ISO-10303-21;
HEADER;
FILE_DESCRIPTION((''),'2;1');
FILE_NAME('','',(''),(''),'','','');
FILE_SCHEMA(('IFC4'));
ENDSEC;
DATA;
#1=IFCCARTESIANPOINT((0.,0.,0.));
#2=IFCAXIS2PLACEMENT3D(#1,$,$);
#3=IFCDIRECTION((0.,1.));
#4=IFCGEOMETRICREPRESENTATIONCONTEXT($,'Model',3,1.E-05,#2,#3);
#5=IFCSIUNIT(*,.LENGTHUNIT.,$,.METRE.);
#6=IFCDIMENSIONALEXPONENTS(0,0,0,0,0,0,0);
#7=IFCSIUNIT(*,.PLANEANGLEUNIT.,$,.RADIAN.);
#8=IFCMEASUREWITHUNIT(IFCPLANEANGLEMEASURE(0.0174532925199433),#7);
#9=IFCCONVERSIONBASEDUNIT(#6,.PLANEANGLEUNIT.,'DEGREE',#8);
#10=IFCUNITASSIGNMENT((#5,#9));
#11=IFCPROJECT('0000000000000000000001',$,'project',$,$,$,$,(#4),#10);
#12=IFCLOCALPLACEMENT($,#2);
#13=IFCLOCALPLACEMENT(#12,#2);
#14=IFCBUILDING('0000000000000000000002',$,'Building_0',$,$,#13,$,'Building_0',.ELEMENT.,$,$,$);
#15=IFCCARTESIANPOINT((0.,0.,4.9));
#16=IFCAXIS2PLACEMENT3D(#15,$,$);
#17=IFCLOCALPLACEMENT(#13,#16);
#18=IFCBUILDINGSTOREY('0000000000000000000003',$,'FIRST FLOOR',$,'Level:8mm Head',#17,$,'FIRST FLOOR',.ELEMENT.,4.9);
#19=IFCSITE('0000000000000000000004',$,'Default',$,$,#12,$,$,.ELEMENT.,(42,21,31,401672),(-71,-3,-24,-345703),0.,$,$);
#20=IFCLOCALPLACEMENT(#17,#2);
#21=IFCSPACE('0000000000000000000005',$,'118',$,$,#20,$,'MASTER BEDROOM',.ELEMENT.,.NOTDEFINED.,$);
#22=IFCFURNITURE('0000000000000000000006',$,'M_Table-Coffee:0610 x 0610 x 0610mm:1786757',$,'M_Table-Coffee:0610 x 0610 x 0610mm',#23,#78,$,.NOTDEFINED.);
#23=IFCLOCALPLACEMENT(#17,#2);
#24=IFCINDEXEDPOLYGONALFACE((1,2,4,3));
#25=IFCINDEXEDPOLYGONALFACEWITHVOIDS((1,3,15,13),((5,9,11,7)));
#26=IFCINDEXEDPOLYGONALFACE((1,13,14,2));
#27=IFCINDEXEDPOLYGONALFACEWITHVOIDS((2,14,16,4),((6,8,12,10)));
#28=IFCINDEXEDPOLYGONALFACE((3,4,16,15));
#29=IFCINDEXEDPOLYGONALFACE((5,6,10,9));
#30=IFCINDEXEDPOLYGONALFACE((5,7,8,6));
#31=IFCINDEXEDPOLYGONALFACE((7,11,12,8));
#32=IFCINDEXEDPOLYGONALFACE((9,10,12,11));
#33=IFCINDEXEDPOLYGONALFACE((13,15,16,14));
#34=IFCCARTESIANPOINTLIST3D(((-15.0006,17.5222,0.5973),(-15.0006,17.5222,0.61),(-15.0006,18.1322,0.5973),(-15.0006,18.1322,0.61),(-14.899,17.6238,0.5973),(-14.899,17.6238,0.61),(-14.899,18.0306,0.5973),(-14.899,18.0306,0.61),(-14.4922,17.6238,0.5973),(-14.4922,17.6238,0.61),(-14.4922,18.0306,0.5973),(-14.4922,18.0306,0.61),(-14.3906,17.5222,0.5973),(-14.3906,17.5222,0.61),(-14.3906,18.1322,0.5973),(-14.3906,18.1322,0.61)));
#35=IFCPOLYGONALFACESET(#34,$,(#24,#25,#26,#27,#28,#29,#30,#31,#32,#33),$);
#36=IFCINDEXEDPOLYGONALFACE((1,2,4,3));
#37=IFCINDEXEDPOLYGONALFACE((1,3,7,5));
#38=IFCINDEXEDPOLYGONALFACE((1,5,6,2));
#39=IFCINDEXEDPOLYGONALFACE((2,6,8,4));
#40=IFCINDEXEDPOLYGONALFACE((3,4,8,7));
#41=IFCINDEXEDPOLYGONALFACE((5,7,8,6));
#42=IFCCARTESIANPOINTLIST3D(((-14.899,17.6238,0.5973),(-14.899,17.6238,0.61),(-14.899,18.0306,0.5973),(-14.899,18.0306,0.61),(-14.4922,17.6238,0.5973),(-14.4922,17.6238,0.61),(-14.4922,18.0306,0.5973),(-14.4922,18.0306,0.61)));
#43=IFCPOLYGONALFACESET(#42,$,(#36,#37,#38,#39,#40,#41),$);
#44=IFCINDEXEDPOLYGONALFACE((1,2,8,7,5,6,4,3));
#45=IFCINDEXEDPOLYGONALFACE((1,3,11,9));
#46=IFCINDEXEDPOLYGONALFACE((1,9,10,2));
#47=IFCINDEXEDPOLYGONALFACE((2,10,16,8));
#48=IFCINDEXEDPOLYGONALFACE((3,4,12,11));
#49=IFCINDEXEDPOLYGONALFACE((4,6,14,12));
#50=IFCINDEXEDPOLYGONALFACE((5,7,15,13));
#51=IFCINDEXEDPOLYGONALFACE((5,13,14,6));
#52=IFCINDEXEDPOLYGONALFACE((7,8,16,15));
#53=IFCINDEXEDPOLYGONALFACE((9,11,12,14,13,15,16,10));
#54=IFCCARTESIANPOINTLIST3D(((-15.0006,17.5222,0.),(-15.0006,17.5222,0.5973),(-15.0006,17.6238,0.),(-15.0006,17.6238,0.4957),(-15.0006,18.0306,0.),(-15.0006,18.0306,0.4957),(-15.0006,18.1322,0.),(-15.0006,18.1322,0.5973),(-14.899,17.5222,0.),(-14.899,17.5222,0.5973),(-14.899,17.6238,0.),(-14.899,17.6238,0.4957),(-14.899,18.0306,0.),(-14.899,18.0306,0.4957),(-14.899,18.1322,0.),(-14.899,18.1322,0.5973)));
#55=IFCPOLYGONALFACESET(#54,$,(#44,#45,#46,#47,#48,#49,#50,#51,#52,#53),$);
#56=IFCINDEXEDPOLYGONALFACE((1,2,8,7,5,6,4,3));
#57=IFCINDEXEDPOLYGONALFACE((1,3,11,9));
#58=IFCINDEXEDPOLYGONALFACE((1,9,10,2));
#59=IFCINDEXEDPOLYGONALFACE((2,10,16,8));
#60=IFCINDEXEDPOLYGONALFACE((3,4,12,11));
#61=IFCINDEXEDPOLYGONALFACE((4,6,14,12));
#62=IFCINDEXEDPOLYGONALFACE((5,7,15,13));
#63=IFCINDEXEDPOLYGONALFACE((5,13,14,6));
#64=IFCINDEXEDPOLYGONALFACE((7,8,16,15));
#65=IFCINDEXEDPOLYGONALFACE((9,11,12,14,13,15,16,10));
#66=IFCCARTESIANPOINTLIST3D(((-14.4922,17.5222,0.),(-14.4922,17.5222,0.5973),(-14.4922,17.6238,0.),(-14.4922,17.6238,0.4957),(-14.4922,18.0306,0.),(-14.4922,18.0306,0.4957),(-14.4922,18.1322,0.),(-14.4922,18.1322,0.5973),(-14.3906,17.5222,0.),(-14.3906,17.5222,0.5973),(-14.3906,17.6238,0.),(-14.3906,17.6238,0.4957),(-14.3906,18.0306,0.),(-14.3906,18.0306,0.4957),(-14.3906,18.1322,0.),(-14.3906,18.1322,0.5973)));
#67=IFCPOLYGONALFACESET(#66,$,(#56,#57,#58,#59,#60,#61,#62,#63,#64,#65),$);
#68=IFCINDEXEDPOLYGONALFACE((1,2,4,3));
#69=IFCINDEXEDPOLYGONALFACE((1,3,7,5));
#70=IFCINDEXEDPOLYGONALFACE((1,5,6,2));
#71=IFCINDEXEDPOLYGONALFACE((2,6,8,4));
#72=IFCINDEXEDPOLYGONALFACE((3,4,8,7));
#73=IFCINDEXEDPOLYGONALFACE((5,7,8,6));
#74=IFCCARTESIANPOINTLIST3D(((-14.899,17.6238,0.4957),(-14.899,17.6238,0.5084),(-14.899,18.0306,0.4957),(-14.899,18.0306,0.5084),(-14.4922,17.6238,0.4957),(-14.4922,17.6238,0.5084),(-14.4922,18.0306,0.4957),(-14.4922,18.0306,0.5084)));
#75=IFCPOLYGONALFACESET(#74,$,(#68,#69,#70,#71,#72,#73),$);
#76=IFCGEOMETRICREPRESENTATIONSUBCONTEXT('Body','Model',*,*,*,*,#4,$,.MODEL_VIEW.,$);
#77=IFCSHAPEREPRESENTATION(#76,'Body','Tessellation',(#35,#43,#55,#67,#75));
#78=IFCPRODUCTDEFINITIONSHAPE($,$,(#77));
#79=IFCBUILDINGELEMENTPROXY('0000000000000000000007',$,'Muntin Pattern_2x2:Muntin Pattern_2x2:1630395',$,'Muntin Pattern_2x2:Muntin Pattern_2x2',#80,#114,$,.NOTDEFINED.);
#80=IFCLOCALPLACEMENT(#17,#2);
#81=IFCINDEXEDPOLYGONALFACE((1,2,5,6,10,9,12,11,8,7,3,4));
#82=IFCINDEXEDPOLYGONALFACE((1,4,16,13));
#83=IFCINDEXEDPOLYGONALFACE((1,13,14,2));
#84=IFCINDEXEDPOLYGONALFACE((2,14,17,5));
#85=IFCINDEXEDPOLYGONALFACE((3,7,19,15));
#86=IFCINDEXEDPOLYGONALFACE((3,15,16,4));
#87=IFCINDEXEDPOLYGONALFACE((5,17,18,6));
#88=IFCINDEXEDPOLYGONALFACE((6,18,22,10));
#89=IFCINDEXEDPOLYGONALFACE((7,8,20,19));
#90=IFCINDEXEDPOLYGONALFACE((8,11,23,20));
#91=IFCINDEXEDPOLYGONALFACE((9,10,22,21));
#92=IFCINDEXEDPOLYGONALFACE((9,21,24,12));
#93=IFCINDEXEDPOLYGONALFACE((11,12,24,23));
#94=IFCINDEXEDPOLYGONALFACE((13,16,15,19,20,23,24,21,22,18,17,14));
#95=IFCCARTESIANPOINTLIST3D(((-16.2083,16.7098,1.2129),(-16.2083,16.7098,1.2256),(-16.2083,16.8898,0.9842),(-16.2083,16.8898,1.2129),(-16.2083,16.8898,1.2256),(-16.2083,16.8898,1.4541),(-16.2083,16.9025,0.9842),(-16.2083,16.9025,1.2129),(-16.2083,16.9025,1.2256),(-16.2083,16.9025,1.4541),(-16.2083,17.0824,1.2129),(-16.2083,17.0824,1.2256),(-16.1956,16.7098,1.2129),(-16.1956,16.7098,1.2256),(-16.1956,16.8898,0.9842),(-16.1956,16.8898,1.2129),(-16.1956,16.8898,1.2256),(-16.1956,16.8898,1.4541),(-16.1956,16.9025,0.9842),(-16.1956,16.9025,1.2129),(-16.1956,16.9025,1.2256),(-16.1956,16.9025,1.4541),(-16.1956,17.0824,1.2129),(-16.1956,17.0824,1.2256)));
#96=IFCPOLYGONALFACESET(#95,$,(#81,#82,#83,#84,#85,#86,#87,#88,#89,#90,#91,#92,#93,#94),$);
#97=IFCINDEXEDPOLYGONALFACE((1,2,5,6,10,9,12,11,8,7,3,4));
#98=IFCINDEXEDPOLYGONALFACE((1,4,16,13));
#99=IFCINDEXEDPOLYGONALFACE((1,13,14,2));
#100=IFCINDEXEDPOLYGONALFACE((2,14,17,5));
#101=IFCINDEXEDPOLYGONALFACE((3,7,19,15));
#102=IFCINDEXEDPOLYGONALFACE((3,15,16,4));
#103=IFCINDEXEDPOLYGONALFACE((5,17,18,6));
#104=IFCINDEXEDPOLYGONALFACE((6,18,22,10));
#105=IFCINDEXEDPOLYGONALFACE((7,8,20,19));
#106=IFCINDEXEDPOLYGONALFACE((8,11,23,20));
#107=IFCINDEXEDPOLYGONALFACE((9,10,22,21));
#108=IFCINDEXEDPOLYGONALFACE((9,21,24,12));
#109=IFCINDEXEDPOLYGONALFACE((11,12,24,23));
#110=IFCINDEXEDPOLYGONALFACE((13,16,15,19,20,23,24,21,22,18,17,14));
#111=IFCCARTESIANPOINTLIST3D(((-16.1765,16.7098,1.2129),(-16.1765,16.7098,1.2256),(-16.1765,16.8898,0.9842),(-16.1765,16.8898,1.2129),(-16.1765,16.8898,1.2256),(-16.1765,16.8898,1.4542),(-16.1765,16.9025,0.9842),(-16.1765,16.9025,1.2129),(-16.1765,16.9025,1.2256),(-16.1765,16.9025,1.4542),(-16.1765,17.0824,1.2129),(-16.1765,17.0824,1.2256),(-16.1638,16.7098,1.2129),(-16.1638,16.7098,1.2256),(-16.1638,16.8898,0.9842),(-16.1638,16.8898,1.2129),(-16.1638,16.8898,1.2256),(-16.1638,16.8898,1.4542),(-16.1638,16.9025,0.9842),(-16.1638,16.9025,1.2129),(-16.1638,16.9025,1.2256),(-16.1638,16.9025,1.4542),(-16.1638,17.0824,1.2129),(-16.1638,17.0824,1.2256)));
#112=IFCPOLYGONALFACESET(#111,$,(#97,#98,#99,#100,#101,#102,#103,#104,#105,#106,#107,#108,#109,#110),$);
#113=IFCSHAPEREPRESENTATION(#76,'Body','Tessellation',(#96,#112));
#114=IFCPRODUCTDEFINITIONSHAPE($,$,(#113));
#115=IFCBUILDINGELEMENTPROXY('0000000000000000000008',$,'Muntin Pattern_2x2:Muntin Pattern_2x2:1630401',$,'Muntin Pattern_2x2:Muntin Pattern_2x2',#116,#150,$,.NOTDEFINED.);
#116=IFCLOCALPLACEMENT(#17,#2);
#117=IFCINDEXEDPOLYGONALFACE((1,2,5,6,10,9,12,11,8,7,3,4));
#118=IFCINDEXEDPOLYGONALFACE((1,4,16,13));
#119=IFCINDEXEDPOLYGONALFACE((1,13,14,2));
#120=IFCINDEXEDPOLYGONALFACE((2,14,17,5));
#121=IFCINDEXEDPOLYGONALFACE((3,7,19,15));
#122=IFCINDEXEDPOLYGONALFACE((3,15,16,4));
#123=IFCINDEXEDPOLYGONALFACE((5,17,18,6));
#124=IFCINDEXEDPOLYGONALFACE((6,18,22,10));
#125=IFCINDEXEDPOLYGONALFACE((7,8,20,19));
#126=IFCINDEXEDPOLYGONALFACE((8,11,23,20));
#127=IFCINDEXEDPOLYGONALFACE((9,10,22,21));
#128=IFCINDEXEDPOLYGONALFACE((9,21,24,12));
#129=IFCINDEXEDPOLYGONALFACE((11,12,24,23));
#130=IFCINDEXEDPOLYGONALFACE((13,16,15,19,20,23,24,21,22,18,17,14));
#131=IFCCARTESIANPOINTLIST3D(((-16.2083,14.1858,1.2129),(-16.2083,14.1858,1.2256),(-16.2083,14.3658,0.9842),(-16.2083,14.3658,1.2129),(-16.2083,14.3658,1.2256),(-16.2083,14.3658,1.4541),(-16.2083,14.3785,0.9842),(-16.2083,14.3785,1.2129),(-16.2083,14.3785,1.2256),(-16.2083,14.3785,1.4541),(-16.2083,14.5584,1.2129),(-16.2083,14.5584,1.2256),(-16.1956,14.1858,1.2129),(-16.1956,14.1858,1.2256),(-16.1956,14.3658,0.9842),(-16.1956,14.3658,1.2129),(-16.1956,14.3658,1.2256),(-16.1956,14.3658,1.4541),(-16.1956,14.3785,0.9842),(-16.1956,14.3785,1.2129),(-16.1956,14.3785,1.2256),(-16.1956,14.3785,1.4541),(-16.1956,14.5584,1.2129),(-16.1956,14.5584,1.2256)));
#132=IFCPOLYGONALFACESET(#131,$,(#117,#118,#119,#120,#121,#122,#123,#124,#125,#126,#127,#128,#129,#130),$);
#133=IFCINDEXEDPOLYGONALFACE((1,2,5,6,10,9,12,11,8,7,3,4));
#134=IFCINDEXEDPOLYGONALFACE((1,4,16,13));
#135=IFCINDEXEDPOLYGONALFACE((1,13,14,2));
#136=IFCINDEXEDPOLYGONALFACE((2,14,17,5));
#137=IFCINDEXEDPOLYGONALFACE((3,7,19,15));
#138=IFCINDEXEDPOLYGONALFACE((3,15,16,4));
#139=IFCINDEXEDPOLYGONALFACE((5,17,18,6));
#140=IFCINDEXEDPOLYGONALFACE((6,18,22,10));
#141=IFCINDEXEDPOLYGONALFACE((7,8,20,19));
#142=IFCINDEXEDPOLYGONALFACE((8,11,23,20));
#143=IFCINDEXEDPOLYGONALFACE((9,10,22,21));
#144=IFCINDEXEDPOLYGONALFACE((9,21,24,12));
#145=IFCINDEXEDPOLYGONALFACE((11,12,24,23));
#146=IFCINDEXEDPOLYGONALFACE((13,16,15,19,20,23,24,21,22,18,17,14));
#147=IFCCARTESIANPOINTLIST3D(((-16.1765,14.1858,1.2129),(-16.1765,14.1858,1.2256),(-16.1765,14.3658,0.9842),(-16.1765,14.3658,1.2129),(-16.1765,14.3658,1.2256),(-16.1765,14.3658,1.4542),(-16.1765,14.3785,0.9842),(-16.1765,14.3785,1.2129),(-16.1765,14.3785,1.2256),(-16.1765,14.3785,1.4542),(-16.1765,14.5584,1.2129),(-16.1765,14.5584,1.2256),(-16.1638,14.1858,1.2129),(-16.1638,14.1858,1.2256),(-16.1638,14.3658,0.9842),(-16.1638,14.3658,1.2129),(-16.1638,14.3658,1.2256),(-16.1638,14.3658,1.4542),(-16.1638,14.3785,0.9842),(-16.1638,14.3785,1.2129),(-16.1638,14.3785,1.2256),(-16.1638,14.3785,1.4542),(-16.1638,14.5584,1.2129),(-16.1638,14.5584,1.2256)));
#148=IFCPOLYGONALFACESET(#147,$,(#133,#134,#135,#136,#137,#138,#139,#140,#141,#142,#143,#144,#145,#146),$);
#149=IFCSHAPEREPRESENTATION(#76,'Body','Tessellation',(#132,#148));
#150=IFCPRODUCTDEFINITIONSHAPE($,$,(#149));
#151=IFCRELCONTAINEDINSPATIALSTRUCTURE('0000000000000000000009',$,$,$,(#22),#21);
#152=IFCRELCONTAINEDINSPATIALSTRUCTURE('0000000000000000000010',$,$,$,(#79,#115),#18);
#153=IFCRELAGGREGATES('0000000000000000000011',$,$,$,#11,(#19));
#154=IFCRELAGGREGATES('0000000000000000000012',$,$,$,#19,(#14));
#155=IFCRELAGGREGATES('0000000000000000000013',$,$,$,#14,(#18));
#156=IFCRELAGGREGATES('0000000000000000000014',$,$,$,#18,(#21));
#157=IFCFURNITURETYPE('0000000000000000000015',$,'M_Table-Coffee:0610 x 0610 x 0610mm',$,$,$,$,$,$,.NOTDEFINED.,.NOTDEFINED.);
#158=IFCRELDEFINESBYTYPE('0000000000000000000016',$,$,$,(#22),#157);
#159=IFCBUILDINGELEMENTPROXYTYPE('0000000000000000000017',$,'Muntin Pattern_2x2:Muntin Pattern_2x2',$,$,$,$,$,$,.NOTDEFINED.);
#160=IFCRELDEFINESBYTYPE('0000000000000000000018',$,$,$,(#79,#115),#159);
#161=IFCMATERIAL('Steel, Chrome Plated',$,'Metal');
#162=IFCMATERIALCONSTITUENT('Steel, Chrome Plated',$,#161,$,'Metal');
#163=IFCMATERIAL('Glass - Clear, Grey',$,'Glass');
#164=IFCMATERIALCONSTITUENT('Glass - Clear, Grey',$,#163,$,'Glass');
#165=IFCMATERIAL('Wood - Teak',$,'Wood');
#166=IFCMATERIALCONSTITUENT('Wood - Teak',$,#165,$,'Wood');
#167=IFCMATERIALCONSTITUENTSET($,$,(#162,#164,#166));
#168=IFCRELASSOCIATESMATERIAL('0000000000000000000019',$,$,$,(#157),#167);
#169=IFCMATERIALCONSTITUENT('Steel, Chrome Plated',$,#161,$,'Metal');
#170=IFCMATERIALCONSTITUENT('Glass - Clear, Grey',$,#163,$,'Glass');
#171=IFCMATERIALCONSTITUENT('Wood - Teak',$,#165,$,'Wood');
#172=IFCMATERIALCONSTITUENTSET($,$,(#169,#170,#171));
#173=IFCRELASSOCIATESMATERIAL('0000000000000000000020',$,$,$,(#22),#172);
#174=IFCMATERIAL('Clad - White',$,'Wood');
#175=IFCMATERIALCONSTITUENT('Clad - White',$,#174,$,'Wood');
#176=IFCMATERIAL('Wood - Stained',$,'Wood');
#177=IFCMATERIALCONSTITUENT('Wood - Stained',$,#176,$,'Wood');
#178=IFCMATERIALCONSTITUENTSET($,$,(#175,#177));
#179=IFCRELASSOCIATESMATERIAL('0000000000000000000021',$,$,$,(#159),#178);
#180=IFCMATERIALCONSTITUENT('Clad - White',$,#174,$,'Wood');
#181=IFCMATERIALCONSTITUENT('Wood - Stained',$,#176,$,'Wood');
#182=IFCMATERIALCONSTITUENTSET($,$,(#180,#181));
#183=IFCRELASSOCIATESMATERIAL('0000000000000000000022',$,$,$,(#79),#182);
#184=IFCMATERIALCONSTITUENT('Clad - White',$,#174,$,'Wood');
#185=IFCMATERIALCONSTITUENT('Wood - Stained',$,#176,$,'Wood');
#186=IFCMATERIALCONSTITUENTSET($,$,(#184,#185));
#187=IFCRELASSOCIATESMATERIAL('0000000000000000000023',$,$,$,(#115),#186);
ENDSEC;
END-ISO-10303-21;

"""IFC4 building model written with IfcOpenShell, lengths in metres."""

from ifc_helpers import new_model, entity, si_unit, converted_unit, direction, frame, origin, place, context, subcontext, project, spatial, indexed_curve, outline, extrude, source, transform, mapped, material, constituent, constituent_set, type_object, type_shapes, element, save


model = new_model("IFC4")

# Units and contexts
model_context = context("Model", 3, precision=1e-05, world=origin(), true_north=direction((0.0, 1.0)))
body_context = subcontext(model_context, "Body", "Model", "MODEL_VIEW")
ifc_project = project(units=[si_unit("LENGTHUNIT", "METRE"), converted_unit("PLANEANGLEUNIT", "DEGREE", entity("IfcPlaneAngleMeasure", 0.0174532925199433), si_unit("PLANEANGLEUNIT", "RADIAN"), dimensions=[0, 0, 0, 0, 0, 0, 0])], contexts=[model_context])

# Site, building, storey
site_placement = place(None, origin())
site = spatial("IfcSite", under=ifc_project, at=site_placement, Name="Default", CompositionType="ELEMENT", RefLatitude=(42, 21, 31, 401672), RefLongitude=(-71, -3, -24, -345703), RefElevation=0.0)
building_placement = place(site_placement, origin())
building = spatial("IfcBuilding", under=site, at=building_placement, Name="Building_0", LongName="Building_0", CompositionType="ELEMENT")
storey_placement = place(building_placement, frame((0.0, 0.0, 4.9)))
storey = spatial("IfcBuildingStorey", under=building, at=storey_placement, Name="FIRST FLOOR", ObjectType="Level:8mm Head", LongName="FIRST FLOOR", CompositionType="ELEMENT", Elevation=4.9)

# Shared definitions
ifc_material_1 = material(Name="Clad - White", Category="Wood")

# Shared definitions
space_placement = place(storey_placement, origin())
space = spatial("IfcSpace", under=storey, at=space_placement, Name="118", LongName="MASTER BEDROOM", CompositionType="ELEMENT", PredefinedType="NOTDEFINED")

# Furniture
ifc_material_2 = material(Name="Steel, Chrome Plated", Category="Metal")
ifc_constituent_1 = constituent(ifc_material_2, Name="Steel, Chrome Plated", Category="Metal")
ifc_material_3 = material(Name="Glass - Clear, Grey", Category="Glass")
ifc_constituent_2 = constituent(ifc_material_3, Name="Glass - Clear, Grey", Category="Glass")
ifc_material_4 = material(Name="Wood - Teak", Category="Wood")
ifc_constituent_3 = constituent(ifc_material_4, Name="Wood - Teak", Category="Wood")
ifc_constituent_set_1 = constituent_set(constituents=[ifc_constituent_1, ifc_constituent_2, ifc_constituent_3])
ifc_constituent_4 = constituent(ifc_material_2, Name="Steel, Chrome Plated", Category="Metal")
ifc_constituent_5 = constituent(ifc_material_3, Name="Glass - Clear, Grey", Category="Glass")
ifc_constituent_6 = constituent(ifc_material_4, Name="Wood - Teak", Category="Wood")
ifc_constituent_set_2 = constituent_set(constituents=[ifc_constituent_4, ifc_constituent_5, ifc_constituent_6])
furniture_type = type_object("IfcFurnitureType", Name="M_Table-Coffee:0610 x 0610 x 0610mm", AssemblyPlace="NOTDEFINED", PredefinedType="NOTDEFINED", material=ifc_constituent_set_2)
shared_shape_1 = source(origin(), body_context, "Body", "SweptSolid", [
    extrude(outline(indexed_curve([(-0.305, -0.305), (0.305, -0.305), (0.305, 0.305), (-0.305, 0.305), (-0.305, -0.305)], self_intersect=False), holes=[indexed_curve([(-0.2034, -0.2034), (-0.2034, 0.2034), (0.2034, 0.2034), (0.2034, -0.2034), (-0.2034, -0.2034)], self_intersect=False)]), frame((0.0183, 0.0952, 0.5973), z_axis=(0.0, 0.0, 1.0), x_axis=(-1.0, 0.0, 0.0)), (0.0, 0.0, 1.0), 0.0127),
    extrude(outline(indexed_curve([(-0.2034, -0.2034), (0.2034, -0.2034), (0.2034, 0.2034), (-0.2034, 0.2034), (-0.2034, -0.2034)], self_intersect=False)), frame((0.0183, 0.0952, 0.5973), z_axis=(0.0, 0.0, 1.0), x_axis=(-1.0, 0.0, 0.0)), (0.0, 0.0, 1.0), 0.0127),
    extrude(outline(indexed_curve([(-0.305, -0.3241), (0.305, -0.3241), (0.305, 0.2733), (0.2034, 0.2733), (0.2034, -0.2224), (-0.2034, -0.2224), (-0.2034, 0.2733), (-0.305, 0.2733), (-0.305, -0.3241)], self_intersect=False)), frame((-0.2867, 0.0952, 0.2733), z_axis=(1.0, 0.0, 0.0), x_axis=(0.0, -1.0, 0.0)), (0.0, 0.0, 1.0), 0.1016),
    extrude(outline(indexed_curve([(-0.2732, -0.305), (0.324, -0.305), (0.324, 0.305), (-0.2732, 0.305), (-0.2732, 0.2034), (0.2225, 0.2034), (0.2225, -0.2034), (-0.2732, -0.2034), (-0.2732, -0.305)], self_intersect=False)), frame((0.2217, 0.0952, 0.2732), z_axis=(1.0, 0.0, 0.0), x_axis=(0.0, 0.0, 1.0)), (0.0, 0.0, 1.0), 0.1016),
    extrude(outline(indexed_curve([(-0.2034, -0.2034), (0.2034, -0.2034), (0.2034, 0.2034), (-0.2034, 0.2034), (-0.2034, -0.2034)], self_intersect=False)), frame((0.0183, 0.0952, 0.4957), z_axis=(0.0, 0.0, 1.0), x_axis=(-1.0, 0.0, 0.0)), (0.0, 0.0, 1.0), 0.0127),
])
type_shapes(furniture_type, [shared_shape_1])
furniture_placement = place(space_placement, frame((-14.7139, 17.732, 0.0)))
element("IfcFurniture", 1, at=furniture_placement, inside=space, type_object=furniture_type, material=ifc_constituent_set_1, Name="M_Table-Coffee:0610 x 0610 x 0610mm:1786757", ObjectType="M_Table-Coffee:0610 x 0610 x 0610mm", PredefinedType="NOTDEFINED", context=body_context, shape_type="MappedRepresentation", body=[
    mapped(shared_shape_1, transform((0.0, 0.0, 0.0), scale=1.0)),
])

# Building element proxies
ifc_constituent_7 = constituent(ifc_material_1, Name="Clad - White", Category="Wood")
ifc_material_5 = material(Name="Wood - Stained", Category="Wood")
ifc_constituent_8 = constituent(ifc_material_5, Name="Wood - Stained", Category="Wood")
ifc_constituent_set_3 = constituent_set(constituents=[ifc_constituent_7, ifc_constituent_8])
ifc_constituent_9 = constituent(ifc_material_1, Name="Clad - White", Category="Wood")
ifc_constituent_10 = constituent(ifc_material_5, Name="Wood - Stained", Category="Wood")
ifc_constituent_set_4 = constituent_set(constituents=[ifc_constituent_9, ifc_constituent_10])
building_element_proxy_type_1 = type_object("IfcBuildingElementProxyType", Name="Muntin Pattern_2x2:Muntin Pattern_2x2", PredefinedType="NOTDEFINED", material=ifc_constituent_set_4)
shared_shape_2 = source(origin(), body_context, "Body", "SweptSolid", [
    extrude(outline(indexed_curve([(0.0064, -0.0064), (0.2349, -0.0064), (0.2349, 0.0063), (0.0064, 0.0063), (0.0064, 0.1863), (-0.0063, 0.1863), (-0.0063, 0.0063), (-0.235, 0.0063), (-0.235, -0.0064), (-0.0063, -0.0064), (-0.0063, -0.1863), (0.0064, -0.1863), (0.0064, -0.0064)], self_intersect=False)), frame((0.0, 0.0095, 0.235), z_axis=(0.0, 1.0, 0.0), x_axis=(0.0, 0.0, 1.0)), (0.0, 0.0, 1.0), 0.0127),
    extrude(outline(indexed_curve([(0.0064, -0.0064), (0.235, -0.0064), (0.235, 0.0063), (0.0064, 0.0063), (0.0064, 0.1863), (-0.0063, 0.1863), (-0.0063, 0.0063), (-0.235, 0.0063), (-0.235, -0.0064), (-0.0063, -0.0064), (-0.0063, -0.1863), (0.0064, -0.1863), (0.0064, -0.0064)], self_intersect=False)), frame((0.0, -0.0222, 0.235), z_axis=(0.0, 1.0, 0.0), x_axis=(0.0, 0.0, 1.0)), (0.0, 0.0, 1.0), 0.0127),
])
type_shapes(building_element_proxy_type_1, [shared_shape_2])
proxy_1_placement = place(storey_placement, frame((-16.1861, 16.8961, 0.9842), z_axis=(0.0, 0.0, 1.0), x_axis=(0.0, 1.0, 0.0)))
element("IfcBuildingElementProxy", 2, at=proxy_1_placement, inside=storey, type_object=building_element_proxy_type_1, material=ifc_constituent_set_3, Name="Muntin Pattern_2x2:Muntin Pattern_2x2:1630395", ObjectType="Muntin Pattern_2x2:Muntin Pattern_2x2", PredefinedType="NOTDEFINED", context=body_context, shape_type="MappedRepresentation", body=[
    mapped(shared_shape_2, transform((0.0, 0.0, 0.0), scale=1.0)),
])
ifc_constituent_11 = constituent(ifc_material_1, Name="Clad - White", Category="Wood")
ifc_constituent_12 = constituent(ifc_material_5, Name="Wood - Stained", Category="Wood")
ifc_constituent_set_5 = constituent_set(constituents=[ifc_constituent_11, ifc_constituent_12])
proxy_2_placement = place(storey_placement, frame((-16.1861, 14.3721, 0.9842), z_axis=(0.0, 0.0, 1.0), x_axis=(0.0, 1.0, 0.0)))
element("IfcBuildingElementProxy", 3, at=proxy_2_placement, inside=storey, type_object=building_element_proxy_type_1, material=ifc_constituent_set_5, Name="Muntin Pattern_2x2:Muntin Pattern_2x2:1630401", ObjectType="Muntin Pattern_2x2:Muntin Pattern_2x2", PredefinedType="NOTDEFINED", context=body_context, shape_type="MappedRepresentation", body=[
    mapped(shared_shape_2, transform((0.0, 0.0, 0.0), scale=1.0)),
])

save(model, "model.ifc")
